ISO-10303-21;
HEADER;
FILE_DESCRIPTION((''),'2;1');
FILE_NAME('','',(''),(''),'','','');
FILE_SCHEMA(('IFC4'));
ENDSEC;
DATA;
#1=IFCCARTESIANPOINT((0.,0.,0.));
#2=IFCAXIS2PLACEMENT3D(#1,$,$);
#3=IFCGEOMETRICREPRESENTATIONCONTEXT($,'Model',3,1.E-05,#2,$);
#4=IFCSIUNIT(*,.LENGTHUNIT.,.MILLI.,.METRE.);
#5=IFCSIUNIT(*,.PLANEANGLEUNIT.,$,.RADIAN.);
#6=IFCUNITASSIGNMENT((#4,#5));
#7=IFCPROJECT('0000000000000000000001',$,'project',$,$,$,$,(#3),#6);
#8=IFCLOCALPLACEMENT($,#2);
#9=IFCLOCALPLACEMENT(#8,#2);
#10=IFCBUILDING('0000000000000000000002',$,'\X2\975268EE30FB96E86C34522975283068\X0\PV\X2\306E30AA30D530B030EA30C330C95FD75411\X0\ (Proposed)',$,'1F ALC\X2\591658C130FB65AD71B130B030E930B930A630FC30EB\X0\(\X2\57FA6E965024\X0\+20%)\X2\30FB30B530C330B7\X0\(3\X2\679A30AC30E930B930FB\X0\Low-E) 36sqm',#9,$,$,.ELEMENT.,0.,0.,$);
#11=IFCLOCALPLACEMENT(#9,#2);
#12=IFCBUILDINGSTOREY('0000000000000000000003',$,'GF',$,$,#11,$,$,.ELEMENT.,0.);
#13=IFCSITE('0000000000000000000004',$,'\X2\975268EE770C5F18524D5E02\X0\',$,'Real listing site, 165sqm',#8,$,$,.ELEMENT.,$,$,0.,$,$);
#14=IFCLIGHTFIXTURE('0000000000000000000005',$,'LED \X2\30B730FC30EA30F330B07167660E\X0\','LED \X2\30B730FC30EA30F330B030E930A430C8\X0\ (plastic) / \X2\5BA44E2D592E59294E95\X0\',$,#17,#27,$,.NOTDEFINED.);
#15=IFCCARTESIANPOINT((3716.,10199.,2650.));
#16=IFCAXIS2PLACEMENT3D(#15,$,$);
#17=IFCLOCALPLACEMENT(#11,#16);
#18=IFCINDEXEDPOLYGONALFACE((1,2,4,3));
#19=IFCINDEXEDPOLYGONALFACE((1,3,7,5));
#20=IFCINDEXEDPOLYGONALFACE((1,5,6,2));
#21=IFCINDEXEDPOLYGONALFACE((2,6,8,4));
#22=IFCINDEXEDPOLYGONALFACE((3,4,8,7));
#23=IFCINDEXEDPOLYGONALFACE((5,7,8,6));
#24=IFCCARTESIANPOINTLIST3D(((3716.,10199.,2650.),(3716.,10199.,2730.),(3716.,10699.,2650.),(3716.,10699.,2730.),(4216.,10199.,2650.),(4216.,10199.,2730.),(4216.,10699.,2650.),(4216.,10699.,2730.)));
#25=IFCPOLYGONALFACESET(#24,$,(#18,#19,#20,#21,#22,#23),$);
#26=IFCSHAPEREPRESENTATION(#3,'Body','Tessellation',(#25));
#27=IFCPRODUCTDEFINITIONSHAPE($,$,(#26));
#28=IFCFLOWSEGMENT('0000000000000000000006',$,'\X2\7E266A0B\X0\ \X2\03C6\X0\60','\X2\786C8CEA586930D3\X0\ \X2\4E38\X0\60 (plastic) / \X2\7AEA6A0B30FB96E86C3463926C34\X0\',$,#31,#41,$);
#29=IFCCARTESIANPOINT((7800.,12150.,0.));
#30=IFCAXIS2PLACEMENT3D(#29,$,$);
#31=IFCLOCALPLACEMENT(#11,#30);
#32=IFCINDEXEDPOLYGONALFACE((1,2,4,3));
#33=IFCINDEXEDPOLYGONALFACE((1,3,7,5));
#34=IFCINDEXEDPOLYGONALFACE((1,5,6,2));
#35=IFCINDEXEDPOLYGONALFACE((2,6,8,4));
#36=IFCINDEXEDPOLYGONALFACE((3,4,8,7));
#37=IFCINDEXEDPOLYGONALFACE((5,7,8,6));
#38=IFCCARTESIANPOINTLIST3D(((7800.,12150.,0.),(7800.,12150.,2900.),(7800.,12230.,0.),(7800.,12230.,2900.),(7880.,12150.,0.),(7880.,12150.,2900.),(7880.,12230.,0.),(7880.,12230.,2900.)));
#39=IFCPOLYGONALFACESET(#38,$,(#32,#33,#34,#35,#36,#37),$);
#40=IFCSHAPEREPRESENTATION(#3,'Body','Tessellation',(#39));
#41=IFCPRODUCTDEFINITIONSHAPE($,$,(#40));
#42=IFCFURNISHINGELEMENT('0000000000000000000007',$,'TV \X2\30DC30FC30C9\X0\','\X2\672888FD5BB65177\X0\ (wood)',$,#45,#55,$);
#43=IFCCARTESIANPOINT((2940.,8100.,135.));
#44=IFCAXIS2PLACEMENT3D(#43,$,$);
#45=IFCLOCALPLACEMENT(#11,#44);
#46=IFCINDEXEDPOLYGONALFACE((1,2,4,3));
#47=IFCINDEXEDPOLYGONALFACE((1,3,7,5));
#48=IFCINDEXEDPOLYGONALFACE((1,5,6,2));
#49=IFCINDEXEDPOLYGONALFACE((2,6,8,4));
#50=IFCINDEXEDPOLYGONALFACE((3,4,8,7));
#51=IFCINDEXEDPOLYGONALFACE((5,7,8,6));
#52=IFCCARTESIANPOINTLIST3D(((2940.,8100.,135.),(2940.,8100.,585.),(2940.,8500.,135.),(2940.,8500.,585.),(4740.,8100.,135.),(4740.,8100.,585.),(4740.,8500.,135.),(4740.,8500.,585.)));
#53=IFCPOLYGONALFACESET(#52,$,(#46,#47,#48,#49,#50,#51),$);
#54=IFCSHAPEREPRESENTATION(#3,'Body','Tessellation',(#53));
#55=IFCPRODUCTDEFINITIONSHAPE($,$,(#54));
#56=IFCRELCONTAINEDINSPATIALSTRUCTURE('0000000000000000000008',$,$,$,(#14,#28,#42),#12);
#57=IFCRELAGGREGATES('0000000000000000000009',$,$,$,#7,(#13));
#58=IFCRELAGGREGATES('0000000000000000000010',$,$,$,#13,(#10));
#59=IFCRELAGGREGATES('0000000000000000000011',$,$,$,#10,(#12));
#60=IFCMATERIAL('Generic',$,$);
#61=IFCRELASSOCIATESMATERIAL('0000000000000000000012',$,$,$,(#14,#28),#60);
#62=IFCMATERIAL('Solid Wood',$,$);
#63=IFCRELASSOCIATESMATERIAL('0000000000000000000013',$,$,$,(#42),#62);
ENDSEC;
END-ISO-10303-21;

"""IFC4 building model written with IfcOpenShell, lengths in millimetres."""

from ifc_helpers import new_model, si_unit, frame, frame_2d, origin, place, context, project, spatial, rectangle, extrude, material, element, save


model = new_model("IFC4")

# Units and contexts
model_context = context("Model", 3, precision=1e-05, world=origin())
ifc_project = project(units=[si_unit("LENGTHUNIT", "METRE", prefix="MILLI"), si_unit("PLANEANGLEUNIT", "RADIAN")], contexts=[model_context])

# Site, building, storey
site_placement = place(None, origin())
site = spatial("IfcSite", under=ifc_project, at=site_placement, Name="青森県弘前市", ObjectType="Real listing site, 165sqm", CompositionType="ELEMENT", RefElevation=0.0)
building_placement = place(site_placement, origin())
building = spatial("IfcBuilding", under=site, at=building_placement, Name="青森・雨水利用とPVのオフグリッド志向 (Proposed)", ObjectType="1F ALC外壁・断熱グラスウール(基準値+20%)・サッシ(3枚ガラス・Low-E) 36sqm", CompositionType="ELEMENT", ElevationOfRefHeight=0.0, ElevationOfTerrain=0.0)
storey_placement = place(building_placement, origin())
storey = spatial("IfcBuildingStorey", under=building, at=storey_placement, Name="GF", CompositionType="ELEMENT", Elevation=0.0)

# Shared definitions
ifc_material_1 = material(Name="Solid Wood")

# Shared definitions
ifc_material_2 = material(Name="Generic")

# Light fixture
light_fixture_1_placement = place(storey_placement, frame((3716.0, 10199.0, 2650.0)))
element("IfcLightFixture", 1, at=light_fixture_1_placement, inside=storey, material=ifc_material_2, Name="LED シーリング照明", Description="LED シーリングライト (plastic) / 室中央天井", PredefinedType="NOTDEFINED", context=model_context, shape_type="SweptSolid", body=[
    extrude(rectangle(XDim=500.0, YDim=500.0, at=frame_2d((250.0, 250.0))), frame((3716.0, 10199.0, 2650.0)), (0.0, 0.0, 1.0), 80.0),
])

# Flow segment
flow_segment_placement = place(storey_placement, frame((7800.0, 12150.0, 0.0)))
element("IfcFlowSegment", 2, at=flow_segment_placement, inside=storey, material=ifc_material_2, Name="縦樋 φ60", Description="硬質塩ビ 丸60 (plastic) / 竪樋・雨水排水", context=model_context, shape_type="SweptSolid", body=[
    extrude(rectangle(XDim=80.0, YDim=80.0, at=frame_2d((40.0, 40.0))), frame((7800.0, 12150.0, 0.0)), (0.0, 0.0, 1.0), 2900.0),
])

# Furnishing element
furnishing_placement = place(storey_placement, frame((2940.0, 8100.0, 135.0)))
element("IfcFurnishingElement", 3, at=furnishing_placement, inside=storey, material=ifc_material_1, Name="TV ボード", Description="木製家具 (wood)", context=model_context, shape_type="SweptSolid", body=[
    extrude(rectangle(XDim=1800.0, YDim=400.0, at=frame_2d((900.0, 200.0))), frame((2940.0, 8100.0, 135.0)), (0.0, 0.0, 1.0), 450.0),
])

save(model, "model.ifc")
